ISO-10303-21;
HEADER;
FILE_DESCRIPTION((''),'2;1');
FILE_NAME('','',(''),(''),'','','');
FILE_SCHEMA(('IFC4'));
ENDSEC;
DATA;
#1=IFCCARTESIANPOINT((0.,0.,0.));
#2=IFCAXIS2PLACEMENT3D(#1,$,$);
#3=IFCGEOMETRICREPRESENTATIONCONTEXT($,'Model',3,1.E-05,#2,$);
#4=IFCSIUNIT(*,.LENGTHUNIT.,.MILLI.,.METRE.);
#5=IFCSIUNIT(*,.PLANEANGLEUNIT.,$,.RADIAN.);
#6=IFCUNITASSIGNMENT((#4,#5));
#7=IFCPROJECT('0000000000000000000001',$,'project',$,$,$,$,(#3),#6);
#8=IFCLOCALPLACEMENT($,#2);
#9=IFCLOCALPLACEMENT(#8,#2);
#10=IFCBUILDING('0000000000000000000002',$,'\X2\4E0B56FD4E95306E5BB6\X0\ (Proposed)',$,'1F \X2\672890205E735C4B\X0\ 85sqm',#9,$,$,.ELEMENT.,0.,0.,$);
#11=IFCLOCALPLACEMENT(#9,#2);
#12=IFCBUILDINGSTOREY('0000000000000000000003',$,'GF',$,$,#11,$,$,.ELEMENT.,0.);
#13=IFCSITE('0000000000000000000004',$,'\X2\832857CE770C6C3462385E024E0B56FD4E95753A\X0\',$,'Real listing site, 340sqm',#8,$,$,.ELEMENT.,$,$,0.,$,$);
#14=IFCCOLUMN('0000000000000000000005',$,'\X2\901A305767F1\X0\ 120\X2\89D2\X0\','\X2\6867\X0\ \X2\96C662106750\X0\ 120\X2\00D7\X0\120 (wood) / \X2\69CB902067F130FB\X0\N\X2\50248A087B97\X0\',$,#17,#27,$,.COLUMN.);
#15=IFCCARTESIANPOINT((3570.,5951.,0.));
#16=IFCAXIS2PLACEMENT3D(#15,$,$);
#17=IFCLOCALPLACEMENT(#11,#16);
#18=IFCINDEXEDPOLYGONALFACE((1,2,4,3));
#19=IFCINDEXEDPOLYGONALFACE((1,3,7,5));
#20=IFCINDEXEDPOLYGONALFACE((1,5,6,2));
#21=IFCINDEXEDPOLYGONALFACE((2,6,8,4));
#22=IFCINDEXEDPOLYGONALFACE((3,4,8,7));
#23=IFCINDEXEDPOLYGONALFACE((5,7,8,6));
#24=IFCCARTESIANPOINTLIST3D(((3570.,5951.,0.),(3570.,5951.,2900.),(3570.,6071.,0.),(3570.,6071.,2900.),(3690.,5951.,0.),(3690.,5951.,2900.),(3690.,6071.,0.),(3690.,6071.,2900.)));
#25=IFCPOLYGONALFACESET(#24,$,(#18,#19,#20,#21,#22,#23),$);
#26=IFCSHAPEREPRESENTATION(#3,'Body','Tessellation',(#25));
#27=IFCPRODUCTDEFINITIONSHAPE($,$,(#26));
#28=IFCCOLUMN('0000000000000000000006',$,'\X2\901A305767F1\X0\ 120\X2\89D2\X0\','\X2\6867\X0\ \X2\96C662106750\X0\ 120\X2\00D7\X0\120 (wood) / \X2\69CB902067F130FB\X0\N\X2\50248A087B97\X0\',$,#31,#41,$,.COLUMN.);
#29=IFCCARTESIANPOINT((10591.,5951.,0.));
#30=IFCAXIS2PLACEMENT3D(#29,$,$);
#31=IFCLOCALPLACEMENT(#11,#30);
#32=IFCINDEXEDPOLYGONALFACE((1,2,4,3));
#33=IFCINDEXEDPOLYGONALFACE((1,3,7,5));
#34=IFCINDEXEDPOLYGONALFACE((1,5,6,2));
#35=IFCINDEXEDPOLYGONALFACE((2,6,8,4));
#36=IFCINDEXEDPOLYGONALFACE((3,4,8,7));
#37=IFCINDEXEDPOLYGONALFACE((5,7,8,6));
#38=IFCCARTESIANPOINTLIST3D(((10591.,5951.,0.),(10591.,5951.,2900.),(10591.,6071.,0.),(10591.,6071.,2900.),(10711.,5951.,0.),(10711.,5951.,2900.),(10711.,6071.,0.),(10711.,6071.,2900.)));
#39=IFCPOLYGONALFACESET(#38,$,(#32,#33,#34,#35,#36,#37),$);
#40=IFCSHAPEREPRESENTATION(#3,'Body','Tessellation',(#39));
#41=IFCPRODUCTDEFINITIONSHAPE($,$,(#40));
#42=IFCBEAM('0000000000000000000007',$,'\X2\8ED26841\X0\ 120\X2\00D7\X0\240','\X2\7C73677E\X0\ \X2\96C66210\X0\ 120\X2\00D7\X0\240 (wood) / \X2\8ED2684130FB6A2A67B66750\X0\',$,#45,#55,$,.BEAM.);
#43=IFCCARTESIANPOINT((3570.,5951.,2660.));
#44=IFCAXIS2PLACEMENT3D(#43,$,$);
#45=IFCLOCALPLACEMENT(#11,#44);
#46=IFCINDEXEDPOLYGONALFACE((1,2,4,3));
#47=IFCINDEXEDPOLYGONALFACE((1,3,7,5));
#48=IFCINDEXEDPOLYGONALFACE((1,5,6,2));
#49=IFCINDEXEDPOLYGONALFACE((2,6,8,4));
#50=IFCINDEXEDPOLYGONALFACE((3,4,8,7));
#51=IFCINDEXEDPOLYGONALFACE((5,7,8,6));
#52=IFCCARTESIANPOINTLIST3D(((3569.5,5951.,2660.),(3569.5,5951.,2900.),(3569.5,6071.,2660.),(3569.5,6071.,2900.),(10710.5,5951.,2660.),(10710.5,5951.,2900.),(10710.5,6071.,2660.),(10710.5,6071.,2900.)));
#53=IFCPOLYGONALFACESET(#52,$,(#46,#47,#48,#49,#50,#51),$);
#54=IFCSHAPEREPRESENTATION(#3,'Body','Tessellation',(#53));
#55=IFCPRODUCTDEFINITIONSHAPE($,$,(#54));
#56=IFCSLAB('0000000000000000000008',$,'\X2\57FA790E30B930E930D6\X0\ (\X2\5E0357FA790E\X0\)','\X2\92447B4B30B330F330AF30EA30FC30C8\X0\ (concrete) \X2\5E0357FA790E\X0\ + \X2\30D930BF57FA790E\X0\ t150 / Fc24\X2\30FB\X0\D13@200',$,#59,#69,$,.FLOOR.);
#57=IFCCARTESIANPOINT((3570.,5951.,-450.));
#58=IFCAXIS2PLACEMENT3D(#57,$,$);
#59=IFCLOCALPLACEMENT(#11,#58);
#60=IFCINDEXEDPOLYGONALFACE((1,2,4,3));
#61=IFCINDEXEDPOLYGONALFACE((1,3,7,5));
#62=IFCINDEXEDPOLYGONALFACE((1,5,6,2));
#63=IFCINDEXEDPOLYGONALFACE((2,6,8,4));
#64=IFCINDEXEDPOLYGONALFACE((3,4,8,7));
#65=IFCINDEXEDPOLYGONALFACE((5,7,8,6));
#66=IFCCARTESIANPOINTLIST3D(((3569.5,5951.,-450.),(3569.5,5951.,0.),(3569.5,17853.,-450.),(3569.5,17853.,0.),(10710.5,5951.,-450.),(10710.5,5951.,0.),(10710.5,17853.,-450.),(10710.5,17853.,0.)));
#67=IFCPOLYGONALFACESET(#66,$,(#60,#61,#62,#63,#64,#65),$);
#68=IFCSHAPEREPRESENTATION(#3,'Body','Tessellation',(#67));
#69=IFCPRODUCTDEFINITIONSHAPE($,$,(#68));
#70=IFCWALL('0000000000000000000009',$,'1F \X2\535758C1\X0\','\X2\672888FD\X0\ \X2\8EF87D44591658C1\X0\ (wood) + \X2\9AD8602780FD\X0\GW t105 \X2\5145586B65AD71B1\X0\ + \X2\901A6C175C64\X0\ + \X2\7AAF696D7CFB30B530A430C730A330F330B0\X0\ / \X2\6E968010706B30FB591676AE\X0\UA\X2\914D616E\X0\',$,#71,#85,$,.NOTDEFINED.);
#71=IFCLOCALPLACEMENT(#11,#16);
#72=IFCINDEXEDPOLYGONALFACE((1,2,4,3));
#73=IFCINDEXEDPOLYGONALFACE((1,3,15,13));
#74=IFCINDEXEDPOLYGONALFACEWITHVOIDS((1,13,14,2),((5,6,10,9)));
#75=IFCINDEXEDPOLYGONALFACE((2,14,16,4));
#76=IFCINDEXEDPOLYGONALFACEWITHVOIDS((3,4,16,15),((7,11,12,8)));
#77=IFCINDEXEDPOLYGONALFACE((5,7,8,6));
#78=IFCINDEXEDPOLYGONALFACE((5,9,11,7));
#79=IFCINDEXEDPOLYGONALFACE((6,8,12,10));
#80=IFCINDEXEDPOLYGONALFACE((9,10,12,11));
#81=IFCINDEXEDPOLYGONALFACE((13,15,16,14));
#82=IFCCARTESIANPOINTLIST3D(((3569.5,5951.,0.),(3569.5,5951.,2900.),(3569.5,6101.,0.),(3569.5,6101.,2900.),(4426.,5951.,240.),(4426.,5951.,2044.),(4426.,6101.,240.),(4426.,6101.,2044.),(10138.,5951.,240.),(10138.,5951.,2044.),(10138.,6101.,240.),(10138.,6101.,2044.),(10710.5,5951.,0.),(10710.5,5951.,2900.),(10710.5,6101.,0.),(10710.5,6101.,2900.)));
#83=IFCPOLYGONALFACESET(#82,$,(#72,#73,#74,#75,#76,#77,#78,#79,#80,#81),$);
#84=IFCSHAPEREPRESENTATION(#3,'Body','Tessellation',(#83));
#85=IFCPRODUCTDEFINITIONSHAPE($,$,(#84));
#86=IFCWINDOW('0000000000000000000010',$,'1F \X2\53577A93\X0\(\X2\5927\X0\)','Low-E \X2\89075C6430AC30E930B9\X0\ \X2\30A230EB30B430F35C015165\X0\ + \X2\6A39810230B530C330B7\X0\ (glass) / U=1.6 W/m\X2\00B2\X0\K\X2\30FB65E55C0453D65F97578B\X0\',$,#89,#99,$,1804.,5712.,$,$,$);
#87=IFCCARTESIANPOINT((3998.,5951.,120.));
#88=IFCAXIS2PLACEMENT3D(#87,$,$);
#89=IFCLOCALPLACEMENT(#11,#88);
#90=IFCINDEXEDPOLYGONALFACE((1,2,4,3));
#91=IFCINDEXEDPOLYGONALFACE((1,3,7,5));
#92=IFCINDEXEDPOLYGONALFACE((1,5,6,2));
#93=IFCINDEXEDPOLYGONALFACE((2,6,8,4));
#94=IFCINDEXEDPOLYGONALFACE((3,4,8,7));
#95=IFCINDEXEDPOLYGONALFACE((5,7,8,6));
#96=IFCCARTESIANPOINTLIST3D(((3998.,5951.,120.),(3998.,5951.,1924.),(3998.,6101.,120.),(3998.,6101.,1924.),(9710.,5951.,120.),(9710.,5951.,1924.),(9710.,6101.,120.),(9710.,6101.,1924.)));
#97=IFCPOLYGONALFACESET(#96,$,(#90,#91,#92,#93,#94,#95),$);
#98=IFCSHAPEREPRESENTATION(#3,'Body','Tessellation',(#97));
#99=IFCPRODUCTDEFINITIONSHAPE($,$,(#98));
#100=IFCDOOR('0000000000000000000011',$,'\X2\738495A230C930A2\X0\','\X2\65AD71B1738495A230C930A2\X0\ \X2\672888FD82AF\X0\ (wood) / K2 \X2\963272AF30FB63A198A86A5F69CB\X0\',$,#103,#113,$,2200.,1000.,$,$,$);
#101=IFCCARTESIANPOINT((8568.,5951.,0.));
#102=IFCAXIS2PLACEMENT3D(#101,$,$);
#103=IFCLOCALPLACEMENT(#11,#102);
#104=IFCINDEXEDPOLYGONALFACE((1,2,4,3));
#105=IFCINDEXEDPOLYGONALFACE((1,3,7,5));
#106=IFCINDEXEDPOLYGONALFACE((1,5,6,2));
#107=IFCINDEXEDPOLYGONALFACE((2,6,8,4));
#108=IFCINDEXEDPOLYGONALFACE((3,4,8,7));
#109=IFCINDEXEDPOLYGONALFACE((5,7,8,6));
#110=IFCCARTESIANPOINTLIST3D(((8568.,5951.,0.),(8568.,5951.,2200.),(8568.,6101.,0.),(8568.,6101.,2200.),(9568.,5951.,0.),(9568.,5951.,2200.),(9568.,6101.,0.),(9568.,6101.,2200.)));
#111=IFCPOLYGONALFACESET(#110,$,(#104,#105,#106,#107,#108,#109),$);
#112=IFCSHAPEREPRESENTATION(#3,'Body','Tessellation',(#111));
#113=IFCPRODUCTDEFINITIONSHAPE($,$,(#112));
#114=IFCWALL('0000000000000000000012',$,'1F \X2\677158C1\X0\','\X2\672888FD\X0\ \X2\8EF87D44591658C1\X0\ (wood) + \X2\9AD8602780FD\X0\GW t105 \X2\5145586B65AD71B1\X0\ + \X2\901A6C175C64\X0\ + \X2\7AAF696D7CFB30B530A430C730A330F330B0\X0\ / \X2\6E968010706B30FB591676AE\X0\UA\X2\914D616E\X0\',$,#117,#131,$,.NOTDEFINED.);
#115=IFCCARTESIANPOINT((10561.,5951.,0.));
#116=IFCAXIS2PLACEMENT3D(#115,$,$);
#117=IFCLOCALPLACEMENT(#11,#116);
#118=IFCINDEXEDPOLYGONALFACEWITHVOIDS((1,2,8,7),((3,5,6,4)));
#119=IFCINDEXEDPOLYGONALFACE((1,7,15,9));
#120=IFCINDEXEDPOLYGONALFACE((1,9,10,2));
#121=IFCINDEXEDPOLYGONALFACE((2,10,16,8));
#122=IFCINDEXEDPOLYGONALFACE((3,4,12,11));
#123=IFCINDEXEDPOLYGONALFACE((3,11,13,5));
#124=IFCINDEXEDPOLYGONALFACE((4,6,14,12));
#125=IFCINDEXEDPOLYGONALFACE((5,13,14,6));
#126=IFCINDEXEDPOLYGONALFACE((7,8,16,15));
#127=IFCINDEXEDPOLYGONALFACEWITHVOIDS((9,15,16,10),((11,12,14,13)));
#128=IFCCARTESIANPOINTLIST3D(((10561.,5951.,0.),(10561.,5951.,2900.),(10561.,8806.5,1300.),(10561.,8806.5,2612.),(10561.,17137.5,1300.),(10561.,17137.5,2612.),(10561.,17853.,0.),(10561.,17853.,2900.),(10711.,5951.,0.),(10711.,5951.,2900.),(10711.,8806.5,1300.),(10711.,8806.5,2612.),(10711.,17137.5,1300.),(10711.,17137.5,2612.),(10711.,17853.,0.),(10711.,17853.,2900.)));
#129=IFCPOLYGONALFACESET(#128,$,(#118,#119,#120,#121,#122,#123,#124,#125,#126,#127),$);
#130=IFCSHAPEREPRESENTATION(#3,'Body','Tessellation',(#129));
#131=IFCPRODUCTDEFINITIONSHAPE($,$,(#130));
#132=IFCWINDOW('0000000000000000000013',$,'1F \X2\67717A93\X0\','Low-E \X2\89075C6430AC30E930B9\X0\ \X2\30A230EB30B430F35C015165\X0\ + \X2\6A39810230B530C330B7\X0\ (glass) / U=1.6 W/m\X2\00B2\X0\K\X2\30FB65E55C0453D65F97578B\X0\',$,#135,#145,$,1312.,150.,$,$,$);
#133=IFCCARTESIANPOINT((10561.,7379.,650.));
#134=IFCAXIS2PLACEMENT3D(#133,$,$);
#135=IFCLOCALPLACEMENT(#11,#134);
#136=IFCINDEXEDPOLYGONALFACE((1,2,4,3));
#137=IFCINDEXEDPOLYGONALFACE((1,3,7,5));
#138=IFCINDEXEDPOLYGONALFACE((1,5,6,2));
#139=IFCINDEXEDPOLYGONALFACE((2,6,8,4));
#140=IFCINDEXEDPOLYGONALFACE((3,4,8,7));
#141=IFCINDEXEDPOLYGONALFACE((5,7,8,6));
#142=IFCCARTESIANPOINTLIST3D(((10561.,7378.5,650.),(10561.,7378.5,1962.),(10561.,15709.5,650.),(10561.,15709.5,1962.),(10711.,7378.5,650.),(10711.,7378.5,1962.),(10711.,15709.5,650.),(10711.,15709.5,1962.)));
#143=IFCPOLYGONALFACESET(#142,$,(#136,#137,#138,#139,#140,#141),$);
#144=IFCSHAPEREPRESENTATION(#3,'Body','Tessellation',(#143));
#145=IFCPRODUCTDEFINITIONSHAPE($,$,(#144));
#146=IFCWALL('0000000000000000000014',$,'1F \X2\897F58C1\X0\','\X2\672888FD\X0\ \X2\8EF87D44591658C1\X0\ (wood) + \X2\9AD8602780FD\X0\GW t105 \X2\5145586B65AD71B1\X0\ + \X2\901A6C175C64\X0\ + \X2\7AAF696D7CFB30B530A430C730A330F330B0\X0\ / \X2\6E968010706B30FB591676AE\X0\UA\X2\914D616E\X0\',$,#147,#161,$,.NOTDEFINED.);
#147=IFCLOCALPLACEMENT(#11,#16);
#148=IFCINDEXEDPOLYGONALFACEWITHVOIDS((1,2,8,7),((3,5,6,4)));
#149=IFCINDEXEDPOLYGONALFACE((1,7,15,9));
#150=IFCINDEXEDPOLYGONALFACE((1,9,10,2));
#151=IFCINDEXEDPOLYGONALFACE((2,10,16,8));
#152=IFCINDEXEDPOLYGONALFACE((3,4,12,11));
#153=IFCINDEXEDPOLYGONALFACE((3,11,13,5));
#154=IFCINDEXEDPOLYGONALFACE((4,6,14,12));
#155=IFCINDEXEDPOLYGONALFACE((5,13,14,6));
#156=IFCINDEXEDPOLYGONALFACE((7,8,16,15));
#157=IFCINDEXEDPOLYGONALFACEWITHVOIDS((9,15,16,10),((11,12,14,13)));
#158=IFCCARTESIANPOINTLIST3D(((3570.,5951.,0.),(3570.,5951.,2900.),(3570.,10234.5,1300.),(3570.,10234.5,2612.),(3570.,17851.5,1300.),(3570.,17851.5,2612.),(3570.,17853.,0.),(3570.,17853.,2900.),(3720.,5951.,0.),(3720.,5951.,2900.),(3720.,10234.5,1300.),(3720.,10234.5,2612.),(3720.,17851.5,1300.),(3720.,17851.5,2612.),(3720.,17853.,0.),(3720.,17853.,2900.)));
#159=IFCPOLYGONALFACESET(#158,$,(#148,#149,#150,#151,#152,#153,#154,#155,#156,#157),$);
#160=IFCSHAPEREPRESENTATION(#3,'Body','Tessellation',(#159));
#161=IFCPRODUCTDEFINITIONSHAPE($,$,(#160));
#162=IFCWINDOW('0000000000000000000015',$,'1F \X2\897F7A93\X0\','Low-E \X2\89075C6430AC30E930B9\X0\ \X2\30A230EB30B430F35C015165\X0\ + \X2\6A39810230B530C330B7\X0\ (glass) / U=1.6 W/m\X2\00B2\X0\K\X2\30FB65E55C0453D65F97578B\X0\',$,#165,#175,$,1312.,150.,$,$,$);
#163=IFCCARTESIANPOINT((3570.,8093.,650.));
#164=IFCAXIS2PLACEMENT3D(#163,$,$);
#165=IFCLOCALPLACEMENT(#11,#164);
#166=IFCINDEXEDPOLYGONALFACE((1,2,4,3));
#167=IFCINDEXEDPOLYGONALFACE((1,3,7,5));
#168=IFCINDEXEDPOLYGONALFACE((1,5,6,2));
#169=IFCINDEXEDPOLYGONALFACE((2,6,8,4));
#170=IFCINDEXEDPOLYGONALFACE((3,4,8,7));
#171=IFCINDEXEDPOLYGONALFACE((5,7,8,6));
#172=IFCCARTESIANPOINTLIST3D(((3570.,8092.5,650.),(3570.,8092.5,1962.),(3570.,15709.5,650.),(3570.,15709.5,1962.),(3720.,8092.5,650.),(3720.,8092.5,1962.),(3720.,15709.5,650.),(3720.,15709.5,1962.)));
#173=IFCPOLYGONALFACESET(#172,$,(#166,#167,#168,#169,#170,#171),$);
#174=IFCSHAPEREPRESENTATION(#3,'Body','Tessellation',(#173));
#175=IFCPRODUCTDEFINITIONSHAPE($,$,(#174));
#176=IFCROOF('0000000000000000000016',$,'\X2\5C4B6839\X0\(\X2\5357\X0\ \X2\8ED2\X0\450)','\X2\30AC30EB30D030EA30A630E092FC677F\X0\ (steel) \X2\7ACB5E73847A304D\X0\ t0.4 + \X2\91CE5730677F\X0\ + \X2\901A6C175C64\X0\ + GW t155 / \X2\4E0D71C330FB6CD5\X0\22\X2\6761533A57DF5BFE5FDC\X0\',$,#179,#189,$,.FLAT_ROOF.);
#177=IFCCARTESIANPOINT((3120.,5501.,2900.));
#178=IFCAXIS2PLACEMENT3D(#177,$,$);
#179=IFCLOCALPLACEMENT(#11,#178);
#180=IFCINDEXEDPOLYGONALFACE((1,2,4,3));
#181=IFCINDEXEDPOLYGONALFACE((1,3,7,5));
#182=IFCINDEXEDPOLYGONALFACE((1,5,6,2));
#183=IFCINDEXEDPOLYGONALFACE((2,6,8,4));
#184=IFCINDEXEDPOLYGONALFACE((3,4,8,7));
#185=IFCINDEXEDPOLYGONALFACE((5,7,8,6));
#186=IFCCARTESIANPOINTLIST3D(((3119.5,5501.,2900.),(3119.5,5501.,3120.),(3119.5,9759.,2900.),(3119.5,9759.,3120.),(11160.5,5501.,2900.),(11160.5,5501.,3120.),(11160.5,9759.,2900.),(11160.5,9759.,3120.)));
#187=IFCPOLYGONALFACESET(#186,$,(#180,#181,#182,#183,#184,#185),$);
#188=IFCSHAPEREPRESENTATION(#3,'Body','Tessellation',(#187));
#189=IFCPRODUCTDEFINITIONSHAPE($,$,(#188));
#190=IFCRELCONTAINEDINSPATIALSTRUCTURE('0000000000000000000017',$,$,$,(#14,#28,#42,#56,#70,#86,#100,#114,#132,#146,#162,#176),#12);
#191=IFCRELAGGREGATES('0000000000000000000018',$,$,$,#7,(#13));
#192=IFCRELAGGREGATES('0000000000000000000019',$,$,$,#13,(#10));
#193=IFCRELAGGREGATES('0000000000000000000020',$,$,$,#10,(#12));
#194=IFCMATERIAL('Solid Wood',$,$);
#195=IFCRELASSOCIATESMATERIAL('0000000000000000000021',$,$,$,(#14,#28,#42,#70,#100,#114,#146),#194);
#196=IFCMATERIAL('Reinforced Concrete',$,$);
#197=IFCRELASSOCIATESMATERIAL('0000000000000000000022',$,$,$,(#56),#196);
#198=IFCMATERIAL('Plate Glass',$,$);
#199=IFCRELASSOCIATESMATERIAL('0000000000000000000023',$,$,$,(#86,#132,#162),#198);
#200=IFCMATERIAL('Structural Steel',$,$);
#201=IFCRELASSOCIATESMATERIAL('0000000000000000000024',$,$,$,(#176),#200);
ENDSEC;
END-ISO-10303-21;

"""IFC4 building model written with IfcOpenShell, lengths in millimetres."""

from ifc_helpers import new_model, si_unit, frame, frame_2d, origin, place, context, project, spatial, rectangle, extrude, material, element, fill, save


model = new_model("IFC4")

# Units and contexts
model_context = context("Model", 3, precision=1e-05, world=origin())
ifc_project = project(units=[si_unit("LENGTHUNIT", "METRE", prefix="MILLI"), si_unit("PLANEANGLEUNIT", "RADIAN")], contexts=[model_context])

# Site, building, storey
site_placement = place(None, origin())
site = spatial("IfcSite", under=ifc_project, at=site_placement, Name="茨城県水戸市下国井町", ObjectType="Real listing site, 340sqm", CompositionType="ELEMENT", RefElevation=0.0)
building_placement = place(site_placement, origin())
building = spatial("IfcBuilding", under=site, at=building_placement, Name="下国井の家 (Proposed)", ObjectType="1F 木造平屋 85sqm", CompositionType="ELEMENT", ElevationOfRefHeight=0.0, ElevationOfTerrain=0.0)
storey_placement = place(building_placement, origin())
storey = spatial("IfcBuildingStorey", under=building, at=storey_placement, Name="GF", CompositionType="ELEMENT", Elevation=0.0)

# Columns
ifc_material_1 = material(Name="Solid Wood")
column_1_placement = place(storey_placement, frame((3570.0, 5951.0, 0.0)))
element("IfcColumn", 1, at=column_1_placement, inside=storey, material=ifc_material_1, Name="通し柱 120角", Description="桧 集成材 120×120 (wood) / 構造柱・N値計算", PredefinedType="COLUMN", context=model_context, shape_type="SweptSolid", body=[
    extrude(rectangle(XDim=120.0, YDim=120.0, at=frame_2d((60.0, 60.0))), frame((3570.0, 5951.0, 0.0)), (0.0, 0.0, 1.0), 2900.0),
])
column_2_placement = place(storey_placement, frame((10591.0, 5951.0, 0.0)))
element("IfcColumn", 2, at=column_2_placement, inside=storey, material=ifc_material_1, Name="通し柱 120角", Description="桧 集成材 120×120 (wood) / 構造柱・N値計算", PredefinedType="COLUMN", context=model_context, shape_type="SweptSolid", body=[
    extrude(rectangle(XDim=120.0, YDim=120.0, at=frame_2d((60.0, 60.0))), frame((10591.0, 5951.0, 0.0)), (0.0, 0.0, 1.0), 2900.0),
])

# Beam
beam_1_placement = place(storey_placement, frame((3570.0, 5951.0, 2660.0)))
element("IfcBeam", 3, at=beam_1_placement, inside=storey, material=ifc_material_1, Name="軒桁 120×240", Description="米松 集成 120×240 (wood) / 軒桁・横架材", PredefinedType="BEAM", context=model_context, shape_type="SweptSolid", body=[
    extrude(rectangle(XDim=7141.0, YDim=120.0, at=frame_2d((3570.0, 60.0))), frame((3570.0, 5951.0, 2660.0)), (0.0, 0.0, 1.0), 240.0),
])

# Slab
ifc_material_2 = material(Name="Reinforced Concrete")
slab_1_placement = place(storey_placement, frame((3570.0, 5951.0, -450.0)))
element("IfcSlab", 4, at=slab_1_placement, inside=storey, material=ifc_material_2, Name="基礎スラブ (布基礎)", Description="鉄筋コンクリート (concrete) 布基礎 + ベタ基礎 t150 / Fc24・D13@200", PredefinedType="FLOOR", context=model_context, shape_type="SweptSolid", body=[
    extrude(rectangle(XDim=7141.0, YDim=11902.0, at=frame_2d((3570.0, 5951.0))), frame((3570.0, 5951.0, -450.0)), (0.0, 0.0, 1.0), 450.0),
])

# Wall, openings, window, door
wall_1_placement = place(storey_placement, frame((3570.0, 5951.0, 0.0)))
wall_1 = element("IfcWall", 5, at=wall_1_placement, inside=storey, material=ifc_material_1, Name="1F 南壁", Description="木製 軸組外壁 (wood) + 高性能GW t105 充填断熱 + 通気層 + 窯業系サイディング / 準耐火・外皮UA配慮", PredefinedType="NOTDEFINED", context=model_context, shape_type="SweptSolid", body=[
    extrude(rectangle(XDim=7141.0, YDim=150.0, at=frame_2d((3570.0, 75.0))), frame((3570.0, 5951.0, 0.0)), (0.0, 0.0, 1.0), 2900.0),
])
opening_1_placement = place(storey_placement, frame((3998.0, 5951.0, 120.0)))
opening_1 = element("IfcOpeningElement", 6, at=opening_1_placement, cuts=wall_1, PredefinedType="NOTDEFINED", context=model_context, shape_type="SweptSolid", body=[
    extrude(rectangle(XDim=5712.0, YDim=150.0, at=frame_2d((2856.0, 75.0))), frame((3998.0, 5951.0, 120.0)), (0.0, 0.0, 1.0), 1804.0),
])
opening_2_placement = place(storey_placement, frame((8568.0, 5951.0, 0.0)))
opening_2 = element("IfcOpeningElement", 7, at=opening_2_placement, cuts=wall_1, PredefinedType="NOTDEFINED", context=model_context, shape_type="SweptSolid", body=[
    extrude(rectangle(XDim=1000.0, YDim=150.0, at=frame_2d((500.0, 75.0))), frame((8568.0, 5951.0, 0.0)), (0.0, 0.0, 1.0), 2200.0),
])
ifc_material_3 = material(Name="Plate Glass")
window_1_placement = place(storey_placement, frame((3998.0, 5951.0, 120.0)))
window_1 = element("IfcWindow", 8, at=window_1_placement, inside=storey, material=ifc_material_3, Name="1F 南窓(大)", Description="Low-E 複層ガラス アルゴン封入 + 樹脂サッシ (glass) / U=1.6 W/m²K・日射取得型", OverallHeight=1804.0, OverallWidth=5712.0, context=model_context, shape_type="SweptSolid", body=[
    extrude(rectangle(XDim=5712.0, YDim=150.0, at=frame_2d((2856.0, 75.0))), frame((3998.0, 5951.0, 120.0)), (0.0, 0.0, 1.0), 1804.0),
])
fill(opening_1, window_1)
door_placement = place(storey_placement, frame((8568.0, 5951.0, 0.0)))
door = element("IfcDoor", 9, at=door_placement, inside=storey, material=ifc_material_1, Name="玄関ドア", Description="断熱玄関ドア 木製芯 (wood) / K2 防犯・採風機構", OverallHeight=2200.0, OverallWidth=1000.0, context=model_context, shape_type="SweptSolid", body=[
    extrude(rectangle(XDim=1000.0, YDim=150.0, at=frame_2d((500.0, 75.0))), frame((8568.0, 5951.0, 0.0)), (0.0, 0.0, 1.0), 2200.0),
])
fill(opening_2, door)

# Walls, openings, windows
wall_2_placement = place(storey_placement, frame((10561.0, 5951.0, 0.0)))
wall_2 = element("IfcWall", 10, at=wall_2_placement, inside=storey, material=ifc_material_1, Name="1F 東壁", Description="木製 軸組外壁 (wood) + 高性能GW t105 充填断熱 + 通気層 + 窯業系サイディング / 準耐火・外皮UA配慮", PredefinedType="NOTDEFINED", context=model_context, shape_type="SweptSolid", body=[
    extrude(rectangle(XDim=150.0, YDim=11902.0, at=frame_2d((75.0, 5951.0))), frame((10561.0, 5951.0, 0.0)), (0.0, 0.0, 1.0), 2900.0),
])
opening_3_placement = place(storey_placement, frame((10561.0, 7379.0, 650.0)))
opening_3 = element("IfcOpeningElement", 11, at=opening_3_placement, cuts=wall_2, PredefinedType="NOTDEFINED", context=model_context, shape_type="SweptSolid", body=[
    extrude(rectangle(XDim=150.0, YDim=8331.0, at=frame_2d((75.0, 4165.0))), frame((10561.0, 7379.0, 650.0)), (0.0, 0.0, 1.0), 1312.0),
])
window_2_placement = place(storey_placement, frame((10561.0, 7379.0, 650.0)))
window_2 = element("IfcWindow", 12, at=window_2_placement, inside=storey, material=ifc_material_3, Name="1F 東窓", Description="Low-E 複層ガラス アルゴン封入 + 樹脂サッシ (glass) / U=1.6 W/m²K・日射取得型", OverallHeight=1312.0, OverallWidth=150.0, context=model_context, shape_type="SweptSolid", body=[
    extrude(rectangle(XDim=150.0, YDim=8331.0, at=frame_2d((75.0, 4165.0))), frame((10561.0, 7379.0, 650.0)), (0.0, 0.0, 1.0), 1312.0),
])
fill(opening_3, window_2)
wall_3_placement = place(storey_placement, frame((3570.0, 5951.0, 0.0)))
wall_3 = element("IfcWall", 13, at=wall_3_placement, inside=storey, material=ifc_material_1, Name="1F 西壁", Description="木製 軸組外壁 (wood) + 高性能GW t105 充填断熱 + 通気層 + 窯業系サイディング / 準耐火・外皮UA配慮", PredefinedType="NOTDEFINED", context=model_context, shape_type="SweptSolid", body=[
    extrude(rectangle(XDim=150.0, YDim=11902.0, at=frame_2d((75.0, 5951.0))), frame((3570.0, 5951.0, 0.0)), (0.0, 0.0, 1.0), 2900.0),
])
opening_4_placement = place(storey_placement, frame((3570.0, 8093.0, 650.0)))
opening_4 = element("IfcOpeningElement", 14, at=opening_4_placement, cuts=wall_3, PredefinedType="NOTDEFINED", context=model_context, shape_type="SweptSolid", body=[
    extrude(rectangle(XDim=150.0, YDim=7617.0, at=frame_2d((75.0, 3808.0))), frame((3570.0, 8093.0, 650.0)), (0.0, 0.0, 1.0), 1312.0),
])
window_3_placement = place(storey_placement, frame((3570.0, 8093.0, 650.0)))
window_3 = element("IfcWindow", 15, at=window_3_placement, inside=storey, material=ifc_material_3, Name="1F 西窓", Description="Low-E 複層ガラス アルゴン封入 + 樹脂サッシ (glass) / U=1.6 W/m²K・日射取得型", OverallHeight=1312.0, OverallWidth=150.0, context=model_context, shape_type="SweptSolid", body=[
    extrude(rectangle(XDim=150.0, YDim=7617.0, at=frame_2d((75.0, 3808.0))), frame((3570.0, 8093.0, 650.0)), (0.0, 0.0, 1.0), 1312.0),
])
fill(opening_4, window_3)

# Roof
ifc_material_4 = material(Name="Structural Steel")
roof_placement = place(storey_placement, frame((3120.0, 5501.0, 2900.0)))
element("IfcRoof", 16, at=roof_placement, inside=storey, material=ifc_material_4, Name="屋根(南 軒450)", Description="ガルバリウム鋼板 (steel) 立平葺き t0.4 + 野地板 + 通気層 + GW t155 / 不燃・法22条区域対応", PredefinedType="FLAT_ROOF", context=model_context, shape_type="SweptSolid", body=[
    extrude(rectangle(XDim=8041.0, YDim=4258.0, at=frame_2d((4020.0, 2129.0))), frame((3120.0, 5501.0, 2900.0)), (0.0, 0.0, 1.0), 220.0),
])

save(model, "model.ifc")
